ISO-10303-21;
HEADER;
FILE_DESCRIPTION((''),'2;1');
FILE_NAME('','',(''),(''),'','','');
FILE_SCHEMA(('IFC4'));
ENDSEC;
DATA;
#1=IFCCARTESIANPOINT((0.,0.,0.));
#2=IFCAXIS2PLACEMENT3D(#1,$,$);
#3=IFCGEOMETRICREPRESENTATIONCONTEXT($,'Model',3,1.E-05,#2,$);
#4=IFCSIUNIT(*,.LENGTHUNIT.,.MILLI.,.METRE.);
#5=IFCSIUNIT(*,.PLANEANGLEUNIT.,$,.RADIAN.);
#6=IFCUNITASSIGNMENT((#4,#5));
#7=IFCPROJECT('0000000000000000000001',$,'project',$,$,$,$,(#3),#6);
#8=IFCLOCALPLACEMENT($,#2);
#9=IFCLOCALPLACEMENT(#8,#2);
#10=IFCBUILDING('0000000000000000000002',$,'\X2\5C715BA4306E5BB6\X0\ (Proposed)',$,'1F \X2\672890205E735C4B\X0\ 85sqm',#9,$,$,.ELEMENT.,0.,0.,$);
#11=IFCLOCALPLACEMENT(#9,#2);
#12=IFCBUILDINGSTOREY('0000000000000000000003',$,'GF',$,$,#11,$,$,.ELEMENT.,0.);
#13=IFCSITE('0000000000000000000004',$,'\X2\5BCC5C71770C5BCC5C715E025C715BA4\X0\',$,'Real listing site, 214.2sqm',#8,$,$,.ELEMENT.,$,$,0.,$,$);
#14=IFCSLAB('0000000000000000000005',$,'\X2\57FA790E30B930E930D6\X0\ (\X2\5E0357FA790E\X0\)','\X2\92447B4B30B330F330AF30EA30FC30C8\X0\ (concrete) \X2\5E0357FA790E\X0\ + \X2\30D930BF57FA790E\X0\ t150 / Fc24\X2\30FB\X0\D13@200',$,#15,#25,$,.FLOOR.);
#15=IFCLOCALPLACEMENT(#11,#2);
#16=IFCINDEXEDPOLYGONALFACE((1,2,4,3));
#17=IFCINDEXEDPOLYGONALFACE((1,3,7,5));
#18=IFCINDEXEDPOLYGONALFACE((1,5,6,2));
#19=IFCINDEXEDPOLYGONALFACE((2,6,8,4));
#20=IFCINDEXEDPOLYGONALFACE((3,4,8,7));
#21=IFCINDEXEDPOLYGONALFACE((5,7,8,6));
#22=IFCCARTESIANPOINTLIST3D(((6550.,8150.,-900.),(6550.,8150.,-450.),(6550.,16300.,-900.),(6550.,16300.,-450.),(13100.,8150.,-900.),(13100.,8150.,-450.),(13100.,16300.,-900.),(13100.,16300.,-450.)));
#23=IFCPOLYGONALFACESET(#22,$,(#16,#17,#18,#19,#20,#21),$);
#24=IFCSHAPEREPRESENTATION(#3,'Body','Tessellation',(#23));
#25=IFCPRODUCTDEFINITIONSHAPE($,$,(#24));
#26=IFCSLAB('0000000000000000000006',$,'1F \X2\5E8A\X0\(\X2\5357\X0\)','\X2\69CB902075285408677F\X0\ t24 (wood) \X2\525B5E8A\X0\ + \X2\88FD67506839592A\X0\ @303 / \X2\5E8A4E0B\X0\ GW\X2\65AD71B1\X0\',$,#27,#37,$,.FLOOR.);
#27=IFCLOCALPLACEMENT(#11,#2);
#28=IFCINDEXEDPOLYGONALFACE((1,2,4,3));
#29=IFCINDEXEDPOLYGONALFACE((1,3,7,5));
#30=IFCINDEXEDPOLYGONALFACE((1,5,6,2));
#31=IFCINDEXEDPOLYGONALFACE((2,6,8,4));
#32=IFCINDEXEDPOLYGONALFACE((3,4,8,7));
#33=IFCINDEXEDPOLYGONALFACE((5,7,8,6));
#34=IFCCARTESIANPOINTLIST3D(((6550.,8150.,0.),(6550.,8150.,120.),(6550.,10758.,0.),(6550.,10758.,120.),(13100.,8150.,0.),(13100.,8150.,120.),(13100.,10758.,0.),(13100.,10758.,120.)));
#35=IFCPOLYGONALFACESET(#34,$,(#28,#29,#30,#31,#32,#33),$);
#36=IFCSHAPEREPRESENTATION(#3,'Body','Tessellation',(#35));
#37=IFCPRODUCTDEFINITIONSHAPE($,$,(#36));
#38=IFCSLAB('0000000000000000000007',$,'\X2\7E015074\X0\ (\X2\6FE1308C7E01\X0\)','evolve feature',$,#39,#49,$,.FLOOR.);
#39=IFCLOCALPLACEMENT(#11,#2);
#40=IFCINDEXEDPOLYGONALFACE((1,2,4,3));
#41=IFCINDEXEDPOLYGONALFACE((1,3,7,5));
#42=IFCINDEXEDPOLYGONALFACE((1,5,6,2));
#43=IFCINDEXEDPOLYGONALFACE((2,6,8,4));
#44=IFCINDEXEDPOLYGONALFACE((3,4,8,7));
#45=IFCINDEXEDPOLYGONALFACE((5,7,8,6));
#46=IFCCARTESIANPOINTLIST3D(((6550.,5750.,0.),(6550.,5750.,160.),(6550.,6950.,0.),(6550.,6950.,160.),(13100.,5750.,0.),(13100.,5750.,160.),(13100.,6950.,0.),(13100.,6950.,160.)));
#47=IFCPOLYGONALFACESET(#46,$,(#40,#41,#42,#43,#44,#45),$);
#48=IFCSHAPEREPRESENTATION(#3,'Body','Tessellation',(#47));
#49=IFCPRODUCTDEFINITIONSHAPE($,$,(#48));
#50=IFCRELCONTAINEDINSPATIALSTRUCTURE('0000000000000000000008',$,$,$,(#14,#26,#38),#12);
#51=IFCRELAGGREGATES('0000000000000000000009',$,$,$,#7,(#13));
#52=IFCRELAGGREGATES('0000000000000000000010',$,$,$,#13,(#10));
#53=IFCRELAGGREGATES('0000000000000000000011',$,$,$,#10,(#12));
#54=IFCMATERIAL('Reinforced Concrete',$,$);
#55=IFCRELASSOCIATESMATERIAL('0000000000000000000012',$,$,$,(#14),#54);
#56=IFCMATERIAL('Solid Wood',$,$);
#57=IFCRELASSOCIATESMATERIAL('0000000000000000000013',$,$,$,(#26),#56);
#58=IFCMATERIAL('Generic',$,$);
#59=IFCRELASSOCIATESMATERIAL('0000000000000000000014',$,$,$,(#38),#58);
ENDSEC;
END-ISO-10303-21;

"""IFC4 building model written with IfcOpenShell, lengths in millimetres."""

from ifc_helpers import new_model, si_unit, frame, frame_2d, origin, place, context, project, spatial, rectangle, extrude, material, element, save


model = new_model("IFC4")

# Units and contexts
model_context = context("Model", 3, precision=1e-05, world=origin())
ifc_project = project(units=[si_unit("LENGTHUNIT", "METRE", prefix="MILLI"), si_unit("PLANEANGLEUNIT", "RADIAN")], contexts=[model_context])

# Site, building, storey
site_placement = place(None, origin())
site = spatial("IfcSite", under=ifc_project, at=site_placement, Name="富山県富山市山室", ObjectType="Real listing site, 214.2sqm", CompositionType="ELEMENT", RefElevation=0.0)
building_placement = place(site_placement, origin())
building = spatial("IfcBuilding", under=site, at=building_placement, Name="山室の家 (Proposed)", ObjectType="1F 木造平屋 85sqm", CompositionType="ELEMENT", ElevationOfRefHeight=0.0, ElevationOfTerrain=0.0)
storey_placement = place(building_placement, origin())
storey = spatial("IfcBuildingStorey", under=building, at=storey_placement, Name="GF", CompositionType="ELEMENT", Elevation=0.0)

# Slabs
ifc_material_1 = material(Name="Reinforced Concrete")
slab_1_placement = place(storey_placement, frame((3275.0, 4075.0, -450.0)))
element("IfcSlab", 1, at=slab_1_placement, inside=storey, material=ifc_material_1, Name="基礎スラブ (布基礎)", Description="鉄筋コンクリート (concrete) 布基礎 + ベタ基礎 t150 / Fc24・D13@200", PredefinedType="FLOOR", context=model_context, shape_type="SweptSolid", body=[
    extrude(rectangle(XDim=6550.0, YDim=8150.0, at=frame_2d((3275.0, 4075.0))), frame((3275.0, 4075.0, -450.0)), (0.0, 0.0, 1.0), 450.0),
])
ifc_material_2 = material(Name="Solid Wood")
slab_2_placement = place(storey_placement, frame((3275.0, 4075.0, 0.0)))
element("IfcSlab", 2, at=slab_2_placement, inside=storey, material=ifc_material_2, Name="1F 床(南)", Description="構造用合板 t24 (wood) 剛床 + 製材根太 @303 / 床下 GW断熱", PredefinedType="FLOOR", context=model_context, shape_type="SweptSolid", body=[
    extrude(rectangle(XDim=6550.0, YDim=2608.0, at=frame_2d((3275.0, 1304.0))), frame((3275.0, 4075.0, 0.0)), (0.0, 0.0, 1.0), 120.0),
])
ifc_material_3 = material(Name="Generic")
slab_3_placement = place(storey_placement, frame((3275.0, 2875.0, 0.0)))
element("IfcSlab", 3, at=slab_3_placement, inside=storey, material=ifc_material_3, Name="縁側 (濡れ縁)", Description="evolve feature", PredefinedType="FLOOR", context=model_context, shape_type="SweptSolid", body=[
    extrude(rectangle(XDim=6550.0, YDim=1200.0, at=frame_2d((3275.0, 600.0))), frame((3275.0, 2875.0, 0.0)), (0.0, 0.0, 1.0), 160.0),
])

save(model, "model.ifc")
